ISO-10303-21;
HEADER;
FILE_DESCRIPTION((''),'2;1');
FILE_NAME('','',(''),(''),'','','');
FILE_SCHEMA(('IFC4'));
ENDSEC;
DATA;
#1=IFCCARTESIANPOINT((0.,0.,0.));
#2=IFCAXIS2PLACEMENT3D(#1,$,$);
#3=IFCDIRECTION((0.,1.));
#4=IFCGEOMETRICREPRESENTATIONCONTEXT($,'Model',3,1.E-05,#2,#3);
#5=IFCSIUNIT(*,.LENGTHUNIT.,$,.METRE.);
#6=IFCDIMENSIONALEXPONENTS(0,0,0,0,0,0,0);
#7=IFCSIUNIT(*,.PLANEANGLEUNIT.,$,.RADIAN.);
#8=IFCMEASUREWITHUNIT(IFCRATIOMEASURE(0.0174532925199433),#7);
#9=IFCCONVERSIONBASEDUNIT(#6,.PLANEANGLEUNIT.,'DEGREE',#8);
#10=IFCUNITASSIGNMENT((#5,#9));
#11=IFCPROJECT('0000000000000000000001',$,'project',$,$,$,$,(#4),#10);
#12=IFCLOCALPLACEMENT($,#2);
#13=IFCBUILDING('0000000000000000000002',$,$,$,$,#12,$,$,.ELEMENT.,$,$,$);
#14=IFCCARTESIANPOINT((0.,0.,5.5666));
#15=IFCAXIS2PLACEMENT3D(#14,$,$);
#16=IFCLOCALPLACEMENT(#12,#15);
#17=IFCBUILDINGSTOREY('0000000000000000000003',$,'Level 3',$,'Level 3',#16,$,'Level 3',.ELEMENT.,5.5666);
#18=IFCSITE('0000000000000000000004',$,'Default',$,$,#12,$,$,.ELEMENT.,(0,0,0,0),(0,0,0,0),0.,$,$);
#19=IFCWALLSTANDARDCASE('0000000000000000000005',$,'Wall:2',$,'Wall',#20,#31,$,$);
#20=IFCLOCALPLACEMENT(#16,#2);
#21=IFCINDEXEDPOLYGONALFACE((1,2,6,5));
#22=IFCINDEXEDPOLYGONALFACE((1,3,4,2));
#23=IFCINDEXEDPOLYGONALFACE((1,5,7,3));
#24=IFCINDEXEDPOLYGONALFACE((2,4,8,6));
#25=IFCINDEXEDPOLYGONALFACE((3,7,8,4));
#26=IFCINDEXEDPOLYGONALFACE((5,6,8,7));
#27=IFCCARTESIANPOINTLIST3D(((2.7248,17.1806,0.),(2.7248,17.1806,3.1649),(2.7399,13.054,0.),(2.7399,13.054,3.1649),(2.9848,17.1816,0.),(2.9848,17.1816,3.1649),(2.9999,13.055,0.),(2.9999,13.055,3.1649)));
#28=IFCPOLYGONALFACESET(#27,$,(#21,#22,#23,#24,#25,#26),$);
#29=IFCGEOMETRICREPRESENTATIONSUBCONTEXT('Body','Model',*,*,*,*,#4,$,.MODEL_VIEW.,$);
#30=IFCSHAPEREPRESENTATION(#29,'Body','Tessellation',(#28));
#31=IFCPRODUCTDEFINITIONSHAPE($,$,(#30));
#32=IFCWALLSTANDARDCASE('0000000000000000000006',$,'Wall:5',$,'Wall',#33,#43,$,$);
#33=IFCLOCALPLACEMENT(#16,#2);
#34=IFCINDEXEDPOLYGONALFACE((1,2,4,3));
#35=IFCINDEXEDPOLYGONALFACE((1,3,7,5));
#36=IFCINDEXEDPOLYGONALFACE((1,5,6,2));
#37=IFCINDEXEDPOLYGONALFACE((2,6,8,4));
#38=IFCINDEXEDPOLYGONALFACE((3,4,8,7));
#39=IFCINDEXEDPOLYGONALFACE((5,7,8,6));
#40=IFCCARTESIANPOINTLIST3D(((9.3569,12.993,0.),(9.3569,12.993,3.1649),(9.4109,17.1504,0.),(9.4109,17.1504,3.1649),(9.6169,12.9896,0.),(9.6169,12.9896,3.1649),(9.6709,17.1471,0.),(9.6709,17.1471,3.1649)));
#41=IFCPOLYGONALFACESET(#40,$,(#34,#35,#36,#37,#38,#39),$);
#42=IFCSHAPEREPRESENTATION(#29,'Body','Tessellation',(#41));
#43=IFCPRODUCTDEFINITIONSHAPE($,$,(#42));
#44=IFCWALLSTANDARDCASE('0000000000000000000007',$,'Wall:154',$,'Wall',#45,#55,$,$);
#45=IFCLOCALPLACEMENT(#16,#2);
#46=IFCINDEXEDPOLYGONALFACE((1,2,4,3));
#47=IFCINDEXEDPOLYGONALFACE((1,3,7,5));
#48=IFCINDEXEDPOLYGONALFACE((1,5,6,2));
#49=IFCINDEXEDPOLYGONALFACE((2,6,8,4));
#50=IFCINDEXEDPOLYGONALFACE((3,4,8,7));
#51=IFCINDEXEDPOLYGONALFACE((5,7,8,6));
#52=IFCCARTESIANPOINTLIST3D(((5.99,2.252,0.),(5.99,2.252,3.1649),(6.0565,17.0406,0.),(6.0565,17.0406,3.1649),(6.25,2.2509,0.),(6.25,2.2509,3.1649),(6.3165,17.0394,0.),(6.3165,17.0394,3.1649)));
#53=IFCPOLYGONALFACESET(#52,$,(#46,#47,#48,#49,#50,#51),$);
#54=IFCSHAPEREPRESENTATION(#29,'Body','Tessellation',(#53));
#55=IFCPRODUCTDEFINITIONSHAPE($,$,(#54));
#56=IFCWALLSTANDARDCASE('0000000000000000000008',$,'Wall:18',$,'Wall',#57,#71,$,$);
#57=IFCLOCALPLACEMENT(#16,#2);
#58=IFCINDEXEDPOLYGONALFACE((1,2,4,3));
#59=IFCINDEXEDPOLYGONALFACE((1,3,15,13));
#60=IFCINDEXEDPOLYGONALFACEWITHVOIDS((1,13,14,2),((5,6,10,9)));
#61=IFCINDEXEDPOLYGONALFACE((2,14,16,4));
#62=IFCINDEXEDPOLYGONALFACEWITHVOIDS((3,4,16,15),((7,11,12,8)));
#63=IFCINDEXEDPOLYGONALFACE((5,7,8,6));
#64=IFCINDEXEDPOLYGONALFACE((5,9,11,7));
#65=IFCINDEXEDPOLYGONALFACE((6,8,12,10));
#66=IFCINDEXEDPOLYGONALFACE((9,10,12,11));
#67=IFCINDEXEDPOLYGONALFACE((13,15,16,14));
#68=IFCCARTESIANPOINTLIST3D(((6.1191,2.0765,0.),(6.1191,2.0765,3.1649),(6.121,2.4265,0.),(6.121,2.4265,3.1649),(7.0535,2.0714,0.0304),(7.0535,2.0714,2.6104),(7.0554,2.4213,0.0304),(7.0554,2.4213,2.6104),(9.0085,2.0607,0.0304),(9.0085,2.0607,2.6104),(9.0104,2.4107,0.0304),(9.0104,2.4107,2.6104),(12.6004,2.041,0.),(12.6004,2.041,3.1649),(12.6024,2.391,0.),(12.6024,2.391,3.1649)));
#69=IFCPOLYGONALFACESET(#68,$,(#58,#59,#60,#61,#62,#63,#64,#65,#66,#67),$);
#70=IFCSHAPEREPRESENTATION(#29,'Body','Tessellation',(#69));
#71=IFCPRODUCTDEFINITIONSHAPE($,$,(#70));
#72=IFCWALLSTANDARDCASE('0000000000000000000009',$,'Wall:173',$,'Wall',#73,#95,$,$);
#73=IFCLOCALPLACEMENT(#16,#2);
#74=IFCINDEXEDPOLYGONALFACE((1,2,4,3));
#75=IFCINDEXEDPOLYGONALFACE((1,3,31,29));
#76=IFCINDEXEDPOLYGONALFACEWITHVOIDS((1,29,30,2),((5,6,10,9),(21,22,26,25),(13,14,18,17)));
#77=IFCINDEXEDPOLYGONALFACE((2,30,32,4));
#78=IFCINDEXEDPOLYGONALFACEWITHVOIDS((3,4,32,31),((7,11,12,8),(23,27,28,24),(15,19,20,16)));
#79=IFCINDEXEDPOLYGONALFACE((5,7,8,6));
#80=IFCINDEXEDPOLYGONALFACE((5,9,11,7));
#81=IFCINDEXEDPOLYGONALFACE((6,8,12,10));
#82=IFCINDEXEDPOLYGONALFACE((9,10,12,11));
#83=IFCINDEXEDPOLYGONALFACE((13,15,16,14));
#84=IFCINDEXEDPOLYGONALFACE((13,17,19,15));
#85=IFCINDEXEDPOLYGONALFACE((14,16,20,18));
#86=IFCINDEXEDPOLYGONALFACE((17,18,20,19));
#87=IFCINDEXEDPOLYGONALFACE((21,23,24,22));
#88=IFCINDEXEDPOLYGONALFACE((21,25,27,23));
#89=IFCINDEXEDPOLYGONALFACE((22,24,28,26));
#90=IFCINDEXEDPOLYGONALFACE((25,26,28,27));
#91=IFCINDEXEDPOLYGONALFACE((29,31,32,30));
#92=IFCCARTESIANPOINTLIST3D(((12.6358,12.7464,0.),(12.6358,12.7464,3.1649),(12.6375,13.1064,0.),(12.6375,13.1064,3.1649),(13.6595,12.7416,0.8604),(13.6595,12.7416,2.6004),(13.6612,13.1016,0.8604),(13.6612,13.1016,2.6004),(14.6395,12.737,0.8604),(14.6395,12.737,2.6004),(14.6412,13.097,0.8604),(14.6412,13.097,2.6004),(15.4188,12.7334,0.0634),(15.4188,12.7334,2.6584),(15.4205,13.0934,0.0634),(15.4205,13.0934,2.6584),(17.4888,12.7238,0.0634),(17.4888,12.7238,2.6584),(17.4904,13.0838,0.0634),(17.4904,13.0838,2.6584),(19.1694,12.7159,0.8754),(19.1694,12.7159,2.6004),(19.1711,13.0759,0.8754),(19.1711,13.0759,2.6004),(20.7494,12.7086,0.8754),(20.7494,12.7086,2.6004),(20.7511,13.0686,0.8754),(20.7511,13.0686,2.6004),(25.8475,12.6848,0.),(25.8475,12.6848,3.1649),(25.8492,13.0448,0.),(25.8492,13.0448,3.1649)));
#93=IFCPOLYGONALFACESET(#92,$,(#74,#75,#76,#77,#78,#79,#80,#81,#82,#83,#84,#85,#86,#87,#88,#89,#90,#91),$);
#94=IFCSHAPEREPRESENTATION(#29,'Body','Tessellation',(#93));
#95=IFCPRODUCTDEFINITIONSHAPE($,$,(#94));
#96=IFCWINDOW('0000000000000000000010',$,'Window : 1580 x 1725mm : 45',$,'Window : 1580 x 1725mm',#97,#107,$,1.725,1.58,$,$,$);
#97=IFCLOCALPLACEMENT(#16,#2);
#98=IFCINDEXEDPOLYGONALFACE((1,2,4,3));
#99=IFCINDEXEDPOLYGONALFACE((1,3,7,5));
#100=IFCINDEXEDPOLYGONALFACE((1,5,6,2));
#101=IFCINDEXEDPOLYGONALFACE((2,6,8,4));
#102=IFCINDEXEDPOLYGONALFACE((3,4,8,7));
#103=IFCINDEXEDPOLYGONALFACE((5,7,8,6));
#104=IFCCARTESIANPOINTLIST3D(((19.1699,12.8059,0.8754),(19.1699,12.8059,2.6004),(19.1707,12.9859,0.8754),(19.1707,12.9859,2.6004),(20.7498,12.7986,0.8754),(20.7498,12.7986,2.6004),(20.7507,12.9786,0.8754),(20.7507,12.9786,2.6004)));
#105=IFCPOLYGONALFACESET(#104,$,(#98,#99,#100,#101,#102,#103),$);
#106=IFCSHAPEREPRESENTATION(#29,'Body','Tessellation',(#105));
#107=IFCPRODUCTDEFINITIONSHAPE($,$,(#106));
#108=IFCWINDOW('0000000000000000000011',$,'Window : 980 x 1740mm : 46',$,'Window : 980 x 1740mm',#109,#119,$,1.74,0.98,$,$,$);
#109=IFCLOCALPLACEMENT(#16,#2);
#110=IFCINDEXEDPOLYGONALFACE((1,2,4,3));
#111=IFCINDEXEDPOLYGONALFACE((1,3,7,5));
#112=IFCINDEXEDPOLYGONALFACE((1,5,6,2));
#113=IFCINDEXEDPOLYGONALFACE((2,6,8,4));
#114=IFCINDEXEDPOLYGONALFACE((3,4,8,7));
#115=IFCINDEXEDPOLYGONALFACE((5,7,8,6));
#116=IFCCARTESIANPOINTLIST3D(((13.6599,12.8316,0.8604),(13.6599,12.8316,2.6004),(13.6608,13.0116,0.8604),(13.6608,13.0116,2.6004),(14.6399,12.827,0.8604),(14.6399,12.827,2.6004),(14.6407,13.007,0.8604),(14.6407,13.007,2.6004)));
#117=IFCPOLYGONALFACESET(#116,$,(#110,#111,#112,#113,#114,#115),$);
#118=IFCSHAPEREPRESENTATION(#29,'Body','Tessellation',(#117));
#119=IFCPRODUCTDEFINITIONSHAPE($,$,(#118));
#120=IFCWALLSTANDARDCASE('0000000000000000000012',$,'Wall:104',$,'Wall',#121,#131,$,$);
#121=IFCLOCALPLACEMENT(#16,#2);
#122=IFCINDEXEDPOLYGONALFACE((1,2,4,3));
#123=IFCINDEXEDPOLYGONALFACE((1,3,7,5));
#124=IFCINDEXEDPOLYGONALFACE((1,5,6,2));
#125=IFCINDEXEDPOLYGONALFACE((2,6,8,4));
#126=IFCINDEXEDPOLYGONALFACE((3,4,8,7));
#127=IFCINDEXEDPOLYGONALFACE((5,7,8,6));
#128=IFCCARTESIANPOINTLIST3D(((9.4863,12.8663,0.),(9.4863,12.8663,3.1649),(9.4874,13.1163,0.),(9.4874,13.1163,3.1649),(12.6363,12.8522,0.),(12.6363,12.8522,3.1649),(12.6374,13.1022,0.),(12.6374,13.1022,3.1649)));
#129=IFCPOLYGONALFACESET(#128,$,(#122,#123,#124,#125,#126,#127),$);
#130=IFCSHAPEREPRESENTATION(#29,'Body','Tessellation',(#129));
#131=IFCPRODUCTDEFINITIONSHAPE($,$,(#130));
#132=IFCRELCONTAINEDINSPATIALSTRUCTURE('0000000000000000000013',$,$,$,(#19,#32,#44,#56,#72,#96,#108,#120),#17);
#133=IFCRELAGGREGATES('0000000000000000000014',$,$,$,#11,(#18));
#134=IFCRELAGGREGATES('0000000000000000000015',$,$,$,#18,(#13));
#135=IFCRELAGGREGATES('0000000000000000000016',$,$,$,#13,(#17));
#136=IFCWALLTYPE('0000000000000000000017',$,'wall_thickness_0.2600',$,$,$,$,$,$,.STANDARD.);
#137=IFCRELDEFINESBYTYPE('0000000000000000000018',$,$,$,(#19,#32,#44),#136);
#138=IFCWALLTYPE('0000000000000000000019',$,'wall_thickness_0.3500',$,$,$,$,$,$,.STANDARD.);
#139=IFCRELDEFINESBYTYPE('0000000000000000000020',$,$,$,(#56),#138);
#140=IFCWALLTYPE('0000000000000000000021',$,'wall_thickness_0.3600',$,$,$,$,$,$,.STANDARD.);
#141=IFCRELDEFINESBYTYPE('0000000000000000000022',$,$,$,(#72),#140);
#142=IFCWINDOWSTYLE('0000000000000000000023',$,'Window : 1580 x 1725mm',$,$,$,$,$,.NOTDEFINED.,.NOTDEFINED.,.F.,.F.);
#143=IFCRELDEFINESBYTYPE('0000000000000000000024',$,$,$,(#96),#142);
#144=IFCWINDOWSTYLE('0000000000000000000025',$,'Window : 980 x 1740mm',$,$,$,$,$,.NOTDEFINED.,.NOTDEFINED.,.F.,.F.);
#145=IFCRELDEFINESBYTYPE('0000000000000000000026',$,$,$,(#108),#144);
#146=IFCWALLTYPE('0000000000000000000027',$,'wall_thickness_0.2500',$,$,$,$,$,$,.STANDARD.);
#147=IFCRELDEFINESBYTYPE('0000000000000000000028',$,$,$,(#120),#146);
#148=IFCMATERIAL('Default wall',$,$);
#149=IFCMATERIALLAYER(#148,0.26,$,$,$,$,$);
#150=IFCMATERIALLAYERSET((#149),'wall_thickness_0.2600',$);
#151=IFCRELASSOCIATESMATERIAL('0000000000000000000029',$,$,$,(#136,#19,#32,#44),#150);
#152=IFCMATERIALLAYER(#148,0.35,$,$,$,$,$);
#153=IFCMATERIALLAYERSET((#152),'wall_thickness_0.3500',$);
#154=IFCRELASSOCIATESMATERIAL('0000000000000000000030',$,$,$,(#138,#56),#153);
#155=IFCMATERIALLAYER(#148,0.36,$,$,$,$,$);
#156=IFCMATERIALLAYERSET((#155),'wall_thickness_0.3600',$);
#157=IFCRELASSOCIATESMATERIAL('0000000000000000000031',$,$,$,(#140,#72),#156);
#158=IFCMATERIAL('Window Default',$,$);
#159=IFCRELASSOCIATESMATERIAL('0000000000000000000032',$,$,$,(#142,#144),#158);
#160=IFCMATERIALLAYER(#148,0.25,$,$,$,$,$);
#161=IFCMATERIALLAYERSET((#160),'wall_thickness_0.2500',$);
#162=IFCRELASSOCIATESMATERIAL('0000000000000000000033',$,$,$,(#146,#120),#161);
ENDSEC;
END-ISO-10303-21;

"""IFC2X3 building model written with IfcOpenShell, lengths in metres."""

from ifc_helpers import new_model, entity, si_unit, converted_unit, direction, frame, frame_2d, origin, origin_2d_with_axis, place, context, subcontext, project, spatial, polyline, rectangle, outline, extrude, source, transform, mapped, material, layer, layer_set, layer_usage, type_object, type_shapes, element, fill, save


model = new_model("IFC2X3")

# Units and contexts
model_context = context("Model", 3, precision=1e-05, world=origin(), true_north=direction((0.0, 1.0)))
body_context = subcontext(model_context, "Body", "Model", "MODEL_VIEW")
ifc_project = project(units=[si_unit("LENGTHUNIT", "METRE"), converted_unit("PLANEANGLEUNIT", "DEGREE", entity("IfcRatioMeasure", 0.0174532925199433), si_unit("PLANEANGLEUNIT", "RADIAN"), dimensions=[0, 0, 0, 0, 0, 0, 0])], contexts=[model_context])

# Site, building, storey
placement_1 = place(None, origin())
site = spatial("IfcSite", under=ifc_project, at=placement_1, Name="Default", CompositionType="ELEMENT", RefLatitude=(0, 0, 0, 0), RefLongitude=(0, 0, 0, 0), RefElevation=0.0)
building = spatial("IfcBuilding", under=site, at=placement_1, CompositionType="ELEMENT")
storey_placement = place(placement_1, frame((0.0, 0.0, 5.5666)))
storey = spatial("IfcBuildingStorey", under=building, at=storey_placement, Name="Level 3", ObjectType="Level 3", LongName="Level 3", CompositionType="ELEMENT", Elevation=5.5666)

# Walls
ifc_material_1 = material(Name="Default wall")
ifc_layer_1 = layer(ifc_material_1, 0.26)
ifc_layer_set_1 = layer_set([ifc_layer_1], Name="wall_thickness_0.2600")
ifc_layer_usage_1 = layer_usage(ifc_layer_set_1, "AXIS2", "POSITIVE", -0.13)
wall_type_1 = type_object("IfcWallType", Name="wall_thickness_0.2600", PredefinedType="STANDARD", material=ifc_layer_set_1)
wall_1_placement = place(storey_placement, frame((2.8548, 17.1811, 0.0), z_axis=(0.0, 0.0, 1.0), x_axis=(0.003663, -0.999993, 0.0)))
element("IfcWallStandardCase", 1, at=wall_1_placement, inside=storey, type_object=wall_type_1, material=ifc_layer_usage_1, Name="Wall:2", ObjectType="Wall", context=body_context, shape_type="SweptSolid", body=[
    extrude(outline(polyline([(4.1266, -0.13), (4.1266, 0.13), (0.0, 0.13), (0.0, -0.13), (4.1266, -0.13)])), origin(), (0.0, 0.0, 1.0), 3.1649),
])
wall_2_placement = place(storey_placement, frame((9.5409, 17.1488, 0.0), z_axis=(0.0, 0.0, 1.0), x_axis=(-0.012986, -0.999916, 0.0)))
element("IfcWallStandardCase", 2, at=wall_2_placement, inside=storey, type_object=wall_type_1, material=ifc_layer_usage_1, Name="Wall:5", ObjectType="Wall", context=body_context, shape_type="SweptSolid", body=[
    extrude(outline(polyline([(4.1578, -0.13), (4.1578, 0.13), (0.0, 0.13), (0.0, -0.13), (4.1578, -0.13)])), origin(), (0.0, 0.0, 1.0), 3.1649),
])
wall_3_placement = place(storey_placement, frame((6.1865, 17.04, 0.0), z_axis=(0.0, 0.0, 1.0), x_axis=(-0.004496, -0.99999, 0.0)))
element("IfcWallStandardCase", 3, at=wall_3_placement, inside=storey, type_object=wall_type_1, material=ifc_layer_usage_1, Name="Wall:154", ObjectType="Wall", context=body_context, shape_type="SweptSolid", body=[
    extrude(outline(polyline([(14.7887, -0.13), (14.7887, 0.13), (0.0, 0.13), (0.0, -0.13), (14.7887, -0.13)])), origin(), (0.0, 0.0, 1.0), 3.1649),
])

# Wall, opening
ifc_layer_2 = layer(ifc_material_1, 0.35)
ifc_layer_set_2 = layer_set([ifc_layer_2], Name="wall_thickness_0.3500")
ifc_layer_usage_2 = layer_usage(ifc_layer_set_2, "AXIS2", "POSITIVE", -0.175)
wall_type_2 = type_object("IfcWallType", Name="wall_thickness_0.3500", PredefinedType="STANDARD", material=ifc_layer_set_2)
wall_4_placement = place(storey_placement, frame((6.12, 2.2515, 0.0), z_axis=(0.0, 0.0, 1.0), x_axis=(0.999985, -0.005465, 0.0)))
wall_4 = element("IfcWallStandardCase", 4, at=wall_4_placement, inside=storey, type_object=wall_type_2, material=ifc_layer_usage_2, Name="Wall:18", ObjectType="Wall", context=body_context, shape_type="SweptSolid", body=[
    extrude(outline(polyline([(6.4815, -0.175), (6.4815, 0.175), (0.0, 0.175), (0.0, -0.175), (6.4815, -0.175)])), origin(), (0.0, 0.0, 1.0), 3.1649),
])
opening_1_placement = place(wall_4_placement, frame((0.9344, -0.175, 0.0304)))
element("IfcOpeningElement", 5, at=opening_1_placement, cuts=wall_4, ObjectType="Opening", context=body_context, shape_type="SweptSolid", body=[
    extrude(rectangle(XDim=1.955, YDim=2.58, at=frame_2d((1.29, 0.9775), x_axis=(0.0, 1.0))), frame((0.0, 0.0, 0.0), z_axis=(0.0, 1.0, 0.0), x_axis=(0.0, 0.0, 1.0)), (0.0, 0.0, 1.0), 0.35),
])

# Wall, openings, windows
ifc_layer_3 = layer(ifc_material_1, 0.36)
ifc_layer_set_3 = layer_set([ifc_layer_3], Name="wall_thickness_0.3600")
ifc_layer_usage_3 = layer_usage(ifc_layer_set_3, "AXIS2", "POSITIVE", -0.18)
wall_type_3 = type_object("IfcWallType", Name="wall_thickness_0.3600", PredefinedType="STANDARD", material=ifc_layer_set_3)
wall_5_placement = place(storey_placement, frame((12.6367, 12.9264, 0.0), z_axis=(0.0, 0.0, 1.0), x_axis=(0.999989, -0.004658, 0.0)))
wall_5 = element("IfcWallStandardCase", 6, at=wall_5_placement, inside=storey, type_object=wall_type_3, material=ifc_layer_usage_3, Name="Wall:173", ObjectType="Wall", context=body_context, shape_type="SweptSolid", body=[
    extrude(outline(polyline([(13.2118, -0.18), (13.2118, 0.18), (0.0, 0.18), (0.0, -0.18), (13.2118, -0.18)])), origin(), (0.0, 0.0, 1.0), 3.1649),
])
opening_2_placement = place(wall_5_placement, frame((2.783, -0.18, 0.0634)))
element("IfcOpeningElement", 7, at=opening_2_placement, cuts=wall_5, ObjectType="Opening", context=body_context, shape_type="SweptSolid", body=[
    extrude(rectangle(XDim=2.07, YDim=2.595, at=frame_2d((1.2975, 1.035), x_axis=(0.0, 1.0))), frame((0.0, 0.0, 0.0), z_axis=(0.0, 1.0, 0.0), x_axis=(0.0, 0.0, 1.0)), (0.0, 0.0, 1.0), 0.36),
])
opening_3_placement = place(wall_5_placement, frame((6.5337, -0.18, 0.8754)))
opening_3 = element("IfcOpeningElement", 8, at=opening_3_placement, cuts=wall_5, ObjectType="Opening", context=body_context, shape_type="SweptSolid", body=[
    extrude(rectangle(XDim=1.58, YDim=1.725, at=frame_2d((0.8625, 0.79), x_axis=(0.0, 1.0))), frame((0.0, 0.0, 0.0), z_axis=(0.0, 1.0, 0.0), x_axis=(0.0, 0.0, 1.0)), (0.0, 0.0, 1.0), 0.36),
])
opening_4_placement = place(wall_5_placement, frame((1.0237, -0.18, 0.8604)))
opening_4 = element("IfcOpeningElement", 9, at=opening_4_placement, cuts=wall_5, ObjectType="Opening", context=body_context, shape_type="SweptSolid", body=[
    extrude(rectangle(XDim=0.98, YDim=1.74, at=frame_2d((0.87, 0.49), x_axis=(0.0, 1.0))), frame((0.0, 0.0, 0.0), z_axis=(0.0, 1.0, 0.0), x_axis=(0.0, 0.0, 1.0)), (0.0, 0.0, 1.0), 0.36),
])
ifc_material_2 = material(Name="Window Default")
window_style_1 = type_object("IfcWindowStyle", Name="Window : 1580 x 1725mm", ConstructionType="NOTDEFINED", OperationType="NOTDEFINED", ParameterTakesPrecedence=False, Sizeable=False, material=ifc_material_2)
shared_shape_1 = source(origin(), body_context, "Body", "SweptSolid", [
    extrude(rectangle(XDim=0.18, YDim=1.58, at=origin_2d_with_axis()), frame((0.79, 0.18, 0.0), z_axis=(0.0, 0.0, 1.0), x_axis=(0.0, 1.0, 0.0)), (0.0, 0.0, 1.0), 1.725),
])
type_shapes(window_style_1, [shared_shape_1])
window_1_placement = place(opening_3_placement, origin())
window_1 = element("IfcWindow", 10, at=window_1_placement, inside=storey, type_object=window_style_1, Name="Window : 1580 x 1725mm : 45", ObjectType="Window : 1580 x 1725mm", OverallHeight=1.725, OverallWidth=1.58, context=body_context, shape_type="MappedRepresentation", body=[
    mapped(shared_shape_1, transform((0.0, 0.0, 0.0), scale=1.0)),
])
fill(opening_3, window_1)
window_style_2 = type_object("IfcWindowStyle", Name="Window : 980 x 1740mm", ConstructionType="NOTDEFINED", OperationType="NOTDEFINED", ParameterTakesPrecedence=False, Sizeable=False, material=ifc_material_2)
shared_shape_2 = source(origin(), body_context, "Body", "SweptSolid", [
    extrude(rectangle(XDim=0.18, YDim=0.98, at=origin_2d_with_axis()), frame((0.49, 0.18, 0.0), z_axis=(0.0, 0.0, 1.0), x_axis=(0.0, 1.0, 0.0)), (0.0, 0.0, 1.0), 1.74),
])
type_shapes(window_style_2, [shared_shape_2])
window_2_placement = place(opening_4_placement, origin())
window_2 = element("IfcWindow", 11, at=window_2_placement, inside=storey, type_object=window_style_2, Name="Window : 980 x 1740mm : 46", ObjectType="Window : 980 x 1740mm", OverallHeight=1.74, OverallWidth=0.98, context=body_context, shape_type="MappedRepresentation", body=[
    mapped(shared_shape_2, transform((0.0, 0.0, 0.0), scale=1.0)),
])
fill(opening_4, window_2)

# Wall
ifc_layer_4 = layer(ifc_material_1, 0.25)
ifc_layer_set_4 = layer_set([ifc_layer_4], Name="wall_thickness_0.2500")
ifc_layer_usage_4 = layer_usage(ifc_layer_set_4, "AXIS2", "POSITIVE", -0.125)
wall_type_4 = type_object("IfcWallType", Name="wall_thickness_0.2500", PredefinedType="STANDARD", material=ifc_layer_set_4)
wall_6_placement = place(storey_placement, frame((9.4869, 12.9913, 0.0), z_axis=(0.0, 0.0, 1.0), x_axis=(0.99999, -0.004481, 0.0)))
element("IfcWallStandardCase", 12, at=wall_6_placement, inside=storey, type_object=wall_type_4, material=ifc_layer_usage_4, Name="Wall:104", ObjectType="Wall", context=body_context, shape_type="SweptSolid", body=[
    extrude(outline(polyline([(3.15, -0.125), (3.15, 0.125), (0.0, 0.125), (0.0, -0.125), (3.15, -0.125)])), origin(), (0.0, 0.0, 1.0), 3.1649),
])

save(model, "model.ifc")
